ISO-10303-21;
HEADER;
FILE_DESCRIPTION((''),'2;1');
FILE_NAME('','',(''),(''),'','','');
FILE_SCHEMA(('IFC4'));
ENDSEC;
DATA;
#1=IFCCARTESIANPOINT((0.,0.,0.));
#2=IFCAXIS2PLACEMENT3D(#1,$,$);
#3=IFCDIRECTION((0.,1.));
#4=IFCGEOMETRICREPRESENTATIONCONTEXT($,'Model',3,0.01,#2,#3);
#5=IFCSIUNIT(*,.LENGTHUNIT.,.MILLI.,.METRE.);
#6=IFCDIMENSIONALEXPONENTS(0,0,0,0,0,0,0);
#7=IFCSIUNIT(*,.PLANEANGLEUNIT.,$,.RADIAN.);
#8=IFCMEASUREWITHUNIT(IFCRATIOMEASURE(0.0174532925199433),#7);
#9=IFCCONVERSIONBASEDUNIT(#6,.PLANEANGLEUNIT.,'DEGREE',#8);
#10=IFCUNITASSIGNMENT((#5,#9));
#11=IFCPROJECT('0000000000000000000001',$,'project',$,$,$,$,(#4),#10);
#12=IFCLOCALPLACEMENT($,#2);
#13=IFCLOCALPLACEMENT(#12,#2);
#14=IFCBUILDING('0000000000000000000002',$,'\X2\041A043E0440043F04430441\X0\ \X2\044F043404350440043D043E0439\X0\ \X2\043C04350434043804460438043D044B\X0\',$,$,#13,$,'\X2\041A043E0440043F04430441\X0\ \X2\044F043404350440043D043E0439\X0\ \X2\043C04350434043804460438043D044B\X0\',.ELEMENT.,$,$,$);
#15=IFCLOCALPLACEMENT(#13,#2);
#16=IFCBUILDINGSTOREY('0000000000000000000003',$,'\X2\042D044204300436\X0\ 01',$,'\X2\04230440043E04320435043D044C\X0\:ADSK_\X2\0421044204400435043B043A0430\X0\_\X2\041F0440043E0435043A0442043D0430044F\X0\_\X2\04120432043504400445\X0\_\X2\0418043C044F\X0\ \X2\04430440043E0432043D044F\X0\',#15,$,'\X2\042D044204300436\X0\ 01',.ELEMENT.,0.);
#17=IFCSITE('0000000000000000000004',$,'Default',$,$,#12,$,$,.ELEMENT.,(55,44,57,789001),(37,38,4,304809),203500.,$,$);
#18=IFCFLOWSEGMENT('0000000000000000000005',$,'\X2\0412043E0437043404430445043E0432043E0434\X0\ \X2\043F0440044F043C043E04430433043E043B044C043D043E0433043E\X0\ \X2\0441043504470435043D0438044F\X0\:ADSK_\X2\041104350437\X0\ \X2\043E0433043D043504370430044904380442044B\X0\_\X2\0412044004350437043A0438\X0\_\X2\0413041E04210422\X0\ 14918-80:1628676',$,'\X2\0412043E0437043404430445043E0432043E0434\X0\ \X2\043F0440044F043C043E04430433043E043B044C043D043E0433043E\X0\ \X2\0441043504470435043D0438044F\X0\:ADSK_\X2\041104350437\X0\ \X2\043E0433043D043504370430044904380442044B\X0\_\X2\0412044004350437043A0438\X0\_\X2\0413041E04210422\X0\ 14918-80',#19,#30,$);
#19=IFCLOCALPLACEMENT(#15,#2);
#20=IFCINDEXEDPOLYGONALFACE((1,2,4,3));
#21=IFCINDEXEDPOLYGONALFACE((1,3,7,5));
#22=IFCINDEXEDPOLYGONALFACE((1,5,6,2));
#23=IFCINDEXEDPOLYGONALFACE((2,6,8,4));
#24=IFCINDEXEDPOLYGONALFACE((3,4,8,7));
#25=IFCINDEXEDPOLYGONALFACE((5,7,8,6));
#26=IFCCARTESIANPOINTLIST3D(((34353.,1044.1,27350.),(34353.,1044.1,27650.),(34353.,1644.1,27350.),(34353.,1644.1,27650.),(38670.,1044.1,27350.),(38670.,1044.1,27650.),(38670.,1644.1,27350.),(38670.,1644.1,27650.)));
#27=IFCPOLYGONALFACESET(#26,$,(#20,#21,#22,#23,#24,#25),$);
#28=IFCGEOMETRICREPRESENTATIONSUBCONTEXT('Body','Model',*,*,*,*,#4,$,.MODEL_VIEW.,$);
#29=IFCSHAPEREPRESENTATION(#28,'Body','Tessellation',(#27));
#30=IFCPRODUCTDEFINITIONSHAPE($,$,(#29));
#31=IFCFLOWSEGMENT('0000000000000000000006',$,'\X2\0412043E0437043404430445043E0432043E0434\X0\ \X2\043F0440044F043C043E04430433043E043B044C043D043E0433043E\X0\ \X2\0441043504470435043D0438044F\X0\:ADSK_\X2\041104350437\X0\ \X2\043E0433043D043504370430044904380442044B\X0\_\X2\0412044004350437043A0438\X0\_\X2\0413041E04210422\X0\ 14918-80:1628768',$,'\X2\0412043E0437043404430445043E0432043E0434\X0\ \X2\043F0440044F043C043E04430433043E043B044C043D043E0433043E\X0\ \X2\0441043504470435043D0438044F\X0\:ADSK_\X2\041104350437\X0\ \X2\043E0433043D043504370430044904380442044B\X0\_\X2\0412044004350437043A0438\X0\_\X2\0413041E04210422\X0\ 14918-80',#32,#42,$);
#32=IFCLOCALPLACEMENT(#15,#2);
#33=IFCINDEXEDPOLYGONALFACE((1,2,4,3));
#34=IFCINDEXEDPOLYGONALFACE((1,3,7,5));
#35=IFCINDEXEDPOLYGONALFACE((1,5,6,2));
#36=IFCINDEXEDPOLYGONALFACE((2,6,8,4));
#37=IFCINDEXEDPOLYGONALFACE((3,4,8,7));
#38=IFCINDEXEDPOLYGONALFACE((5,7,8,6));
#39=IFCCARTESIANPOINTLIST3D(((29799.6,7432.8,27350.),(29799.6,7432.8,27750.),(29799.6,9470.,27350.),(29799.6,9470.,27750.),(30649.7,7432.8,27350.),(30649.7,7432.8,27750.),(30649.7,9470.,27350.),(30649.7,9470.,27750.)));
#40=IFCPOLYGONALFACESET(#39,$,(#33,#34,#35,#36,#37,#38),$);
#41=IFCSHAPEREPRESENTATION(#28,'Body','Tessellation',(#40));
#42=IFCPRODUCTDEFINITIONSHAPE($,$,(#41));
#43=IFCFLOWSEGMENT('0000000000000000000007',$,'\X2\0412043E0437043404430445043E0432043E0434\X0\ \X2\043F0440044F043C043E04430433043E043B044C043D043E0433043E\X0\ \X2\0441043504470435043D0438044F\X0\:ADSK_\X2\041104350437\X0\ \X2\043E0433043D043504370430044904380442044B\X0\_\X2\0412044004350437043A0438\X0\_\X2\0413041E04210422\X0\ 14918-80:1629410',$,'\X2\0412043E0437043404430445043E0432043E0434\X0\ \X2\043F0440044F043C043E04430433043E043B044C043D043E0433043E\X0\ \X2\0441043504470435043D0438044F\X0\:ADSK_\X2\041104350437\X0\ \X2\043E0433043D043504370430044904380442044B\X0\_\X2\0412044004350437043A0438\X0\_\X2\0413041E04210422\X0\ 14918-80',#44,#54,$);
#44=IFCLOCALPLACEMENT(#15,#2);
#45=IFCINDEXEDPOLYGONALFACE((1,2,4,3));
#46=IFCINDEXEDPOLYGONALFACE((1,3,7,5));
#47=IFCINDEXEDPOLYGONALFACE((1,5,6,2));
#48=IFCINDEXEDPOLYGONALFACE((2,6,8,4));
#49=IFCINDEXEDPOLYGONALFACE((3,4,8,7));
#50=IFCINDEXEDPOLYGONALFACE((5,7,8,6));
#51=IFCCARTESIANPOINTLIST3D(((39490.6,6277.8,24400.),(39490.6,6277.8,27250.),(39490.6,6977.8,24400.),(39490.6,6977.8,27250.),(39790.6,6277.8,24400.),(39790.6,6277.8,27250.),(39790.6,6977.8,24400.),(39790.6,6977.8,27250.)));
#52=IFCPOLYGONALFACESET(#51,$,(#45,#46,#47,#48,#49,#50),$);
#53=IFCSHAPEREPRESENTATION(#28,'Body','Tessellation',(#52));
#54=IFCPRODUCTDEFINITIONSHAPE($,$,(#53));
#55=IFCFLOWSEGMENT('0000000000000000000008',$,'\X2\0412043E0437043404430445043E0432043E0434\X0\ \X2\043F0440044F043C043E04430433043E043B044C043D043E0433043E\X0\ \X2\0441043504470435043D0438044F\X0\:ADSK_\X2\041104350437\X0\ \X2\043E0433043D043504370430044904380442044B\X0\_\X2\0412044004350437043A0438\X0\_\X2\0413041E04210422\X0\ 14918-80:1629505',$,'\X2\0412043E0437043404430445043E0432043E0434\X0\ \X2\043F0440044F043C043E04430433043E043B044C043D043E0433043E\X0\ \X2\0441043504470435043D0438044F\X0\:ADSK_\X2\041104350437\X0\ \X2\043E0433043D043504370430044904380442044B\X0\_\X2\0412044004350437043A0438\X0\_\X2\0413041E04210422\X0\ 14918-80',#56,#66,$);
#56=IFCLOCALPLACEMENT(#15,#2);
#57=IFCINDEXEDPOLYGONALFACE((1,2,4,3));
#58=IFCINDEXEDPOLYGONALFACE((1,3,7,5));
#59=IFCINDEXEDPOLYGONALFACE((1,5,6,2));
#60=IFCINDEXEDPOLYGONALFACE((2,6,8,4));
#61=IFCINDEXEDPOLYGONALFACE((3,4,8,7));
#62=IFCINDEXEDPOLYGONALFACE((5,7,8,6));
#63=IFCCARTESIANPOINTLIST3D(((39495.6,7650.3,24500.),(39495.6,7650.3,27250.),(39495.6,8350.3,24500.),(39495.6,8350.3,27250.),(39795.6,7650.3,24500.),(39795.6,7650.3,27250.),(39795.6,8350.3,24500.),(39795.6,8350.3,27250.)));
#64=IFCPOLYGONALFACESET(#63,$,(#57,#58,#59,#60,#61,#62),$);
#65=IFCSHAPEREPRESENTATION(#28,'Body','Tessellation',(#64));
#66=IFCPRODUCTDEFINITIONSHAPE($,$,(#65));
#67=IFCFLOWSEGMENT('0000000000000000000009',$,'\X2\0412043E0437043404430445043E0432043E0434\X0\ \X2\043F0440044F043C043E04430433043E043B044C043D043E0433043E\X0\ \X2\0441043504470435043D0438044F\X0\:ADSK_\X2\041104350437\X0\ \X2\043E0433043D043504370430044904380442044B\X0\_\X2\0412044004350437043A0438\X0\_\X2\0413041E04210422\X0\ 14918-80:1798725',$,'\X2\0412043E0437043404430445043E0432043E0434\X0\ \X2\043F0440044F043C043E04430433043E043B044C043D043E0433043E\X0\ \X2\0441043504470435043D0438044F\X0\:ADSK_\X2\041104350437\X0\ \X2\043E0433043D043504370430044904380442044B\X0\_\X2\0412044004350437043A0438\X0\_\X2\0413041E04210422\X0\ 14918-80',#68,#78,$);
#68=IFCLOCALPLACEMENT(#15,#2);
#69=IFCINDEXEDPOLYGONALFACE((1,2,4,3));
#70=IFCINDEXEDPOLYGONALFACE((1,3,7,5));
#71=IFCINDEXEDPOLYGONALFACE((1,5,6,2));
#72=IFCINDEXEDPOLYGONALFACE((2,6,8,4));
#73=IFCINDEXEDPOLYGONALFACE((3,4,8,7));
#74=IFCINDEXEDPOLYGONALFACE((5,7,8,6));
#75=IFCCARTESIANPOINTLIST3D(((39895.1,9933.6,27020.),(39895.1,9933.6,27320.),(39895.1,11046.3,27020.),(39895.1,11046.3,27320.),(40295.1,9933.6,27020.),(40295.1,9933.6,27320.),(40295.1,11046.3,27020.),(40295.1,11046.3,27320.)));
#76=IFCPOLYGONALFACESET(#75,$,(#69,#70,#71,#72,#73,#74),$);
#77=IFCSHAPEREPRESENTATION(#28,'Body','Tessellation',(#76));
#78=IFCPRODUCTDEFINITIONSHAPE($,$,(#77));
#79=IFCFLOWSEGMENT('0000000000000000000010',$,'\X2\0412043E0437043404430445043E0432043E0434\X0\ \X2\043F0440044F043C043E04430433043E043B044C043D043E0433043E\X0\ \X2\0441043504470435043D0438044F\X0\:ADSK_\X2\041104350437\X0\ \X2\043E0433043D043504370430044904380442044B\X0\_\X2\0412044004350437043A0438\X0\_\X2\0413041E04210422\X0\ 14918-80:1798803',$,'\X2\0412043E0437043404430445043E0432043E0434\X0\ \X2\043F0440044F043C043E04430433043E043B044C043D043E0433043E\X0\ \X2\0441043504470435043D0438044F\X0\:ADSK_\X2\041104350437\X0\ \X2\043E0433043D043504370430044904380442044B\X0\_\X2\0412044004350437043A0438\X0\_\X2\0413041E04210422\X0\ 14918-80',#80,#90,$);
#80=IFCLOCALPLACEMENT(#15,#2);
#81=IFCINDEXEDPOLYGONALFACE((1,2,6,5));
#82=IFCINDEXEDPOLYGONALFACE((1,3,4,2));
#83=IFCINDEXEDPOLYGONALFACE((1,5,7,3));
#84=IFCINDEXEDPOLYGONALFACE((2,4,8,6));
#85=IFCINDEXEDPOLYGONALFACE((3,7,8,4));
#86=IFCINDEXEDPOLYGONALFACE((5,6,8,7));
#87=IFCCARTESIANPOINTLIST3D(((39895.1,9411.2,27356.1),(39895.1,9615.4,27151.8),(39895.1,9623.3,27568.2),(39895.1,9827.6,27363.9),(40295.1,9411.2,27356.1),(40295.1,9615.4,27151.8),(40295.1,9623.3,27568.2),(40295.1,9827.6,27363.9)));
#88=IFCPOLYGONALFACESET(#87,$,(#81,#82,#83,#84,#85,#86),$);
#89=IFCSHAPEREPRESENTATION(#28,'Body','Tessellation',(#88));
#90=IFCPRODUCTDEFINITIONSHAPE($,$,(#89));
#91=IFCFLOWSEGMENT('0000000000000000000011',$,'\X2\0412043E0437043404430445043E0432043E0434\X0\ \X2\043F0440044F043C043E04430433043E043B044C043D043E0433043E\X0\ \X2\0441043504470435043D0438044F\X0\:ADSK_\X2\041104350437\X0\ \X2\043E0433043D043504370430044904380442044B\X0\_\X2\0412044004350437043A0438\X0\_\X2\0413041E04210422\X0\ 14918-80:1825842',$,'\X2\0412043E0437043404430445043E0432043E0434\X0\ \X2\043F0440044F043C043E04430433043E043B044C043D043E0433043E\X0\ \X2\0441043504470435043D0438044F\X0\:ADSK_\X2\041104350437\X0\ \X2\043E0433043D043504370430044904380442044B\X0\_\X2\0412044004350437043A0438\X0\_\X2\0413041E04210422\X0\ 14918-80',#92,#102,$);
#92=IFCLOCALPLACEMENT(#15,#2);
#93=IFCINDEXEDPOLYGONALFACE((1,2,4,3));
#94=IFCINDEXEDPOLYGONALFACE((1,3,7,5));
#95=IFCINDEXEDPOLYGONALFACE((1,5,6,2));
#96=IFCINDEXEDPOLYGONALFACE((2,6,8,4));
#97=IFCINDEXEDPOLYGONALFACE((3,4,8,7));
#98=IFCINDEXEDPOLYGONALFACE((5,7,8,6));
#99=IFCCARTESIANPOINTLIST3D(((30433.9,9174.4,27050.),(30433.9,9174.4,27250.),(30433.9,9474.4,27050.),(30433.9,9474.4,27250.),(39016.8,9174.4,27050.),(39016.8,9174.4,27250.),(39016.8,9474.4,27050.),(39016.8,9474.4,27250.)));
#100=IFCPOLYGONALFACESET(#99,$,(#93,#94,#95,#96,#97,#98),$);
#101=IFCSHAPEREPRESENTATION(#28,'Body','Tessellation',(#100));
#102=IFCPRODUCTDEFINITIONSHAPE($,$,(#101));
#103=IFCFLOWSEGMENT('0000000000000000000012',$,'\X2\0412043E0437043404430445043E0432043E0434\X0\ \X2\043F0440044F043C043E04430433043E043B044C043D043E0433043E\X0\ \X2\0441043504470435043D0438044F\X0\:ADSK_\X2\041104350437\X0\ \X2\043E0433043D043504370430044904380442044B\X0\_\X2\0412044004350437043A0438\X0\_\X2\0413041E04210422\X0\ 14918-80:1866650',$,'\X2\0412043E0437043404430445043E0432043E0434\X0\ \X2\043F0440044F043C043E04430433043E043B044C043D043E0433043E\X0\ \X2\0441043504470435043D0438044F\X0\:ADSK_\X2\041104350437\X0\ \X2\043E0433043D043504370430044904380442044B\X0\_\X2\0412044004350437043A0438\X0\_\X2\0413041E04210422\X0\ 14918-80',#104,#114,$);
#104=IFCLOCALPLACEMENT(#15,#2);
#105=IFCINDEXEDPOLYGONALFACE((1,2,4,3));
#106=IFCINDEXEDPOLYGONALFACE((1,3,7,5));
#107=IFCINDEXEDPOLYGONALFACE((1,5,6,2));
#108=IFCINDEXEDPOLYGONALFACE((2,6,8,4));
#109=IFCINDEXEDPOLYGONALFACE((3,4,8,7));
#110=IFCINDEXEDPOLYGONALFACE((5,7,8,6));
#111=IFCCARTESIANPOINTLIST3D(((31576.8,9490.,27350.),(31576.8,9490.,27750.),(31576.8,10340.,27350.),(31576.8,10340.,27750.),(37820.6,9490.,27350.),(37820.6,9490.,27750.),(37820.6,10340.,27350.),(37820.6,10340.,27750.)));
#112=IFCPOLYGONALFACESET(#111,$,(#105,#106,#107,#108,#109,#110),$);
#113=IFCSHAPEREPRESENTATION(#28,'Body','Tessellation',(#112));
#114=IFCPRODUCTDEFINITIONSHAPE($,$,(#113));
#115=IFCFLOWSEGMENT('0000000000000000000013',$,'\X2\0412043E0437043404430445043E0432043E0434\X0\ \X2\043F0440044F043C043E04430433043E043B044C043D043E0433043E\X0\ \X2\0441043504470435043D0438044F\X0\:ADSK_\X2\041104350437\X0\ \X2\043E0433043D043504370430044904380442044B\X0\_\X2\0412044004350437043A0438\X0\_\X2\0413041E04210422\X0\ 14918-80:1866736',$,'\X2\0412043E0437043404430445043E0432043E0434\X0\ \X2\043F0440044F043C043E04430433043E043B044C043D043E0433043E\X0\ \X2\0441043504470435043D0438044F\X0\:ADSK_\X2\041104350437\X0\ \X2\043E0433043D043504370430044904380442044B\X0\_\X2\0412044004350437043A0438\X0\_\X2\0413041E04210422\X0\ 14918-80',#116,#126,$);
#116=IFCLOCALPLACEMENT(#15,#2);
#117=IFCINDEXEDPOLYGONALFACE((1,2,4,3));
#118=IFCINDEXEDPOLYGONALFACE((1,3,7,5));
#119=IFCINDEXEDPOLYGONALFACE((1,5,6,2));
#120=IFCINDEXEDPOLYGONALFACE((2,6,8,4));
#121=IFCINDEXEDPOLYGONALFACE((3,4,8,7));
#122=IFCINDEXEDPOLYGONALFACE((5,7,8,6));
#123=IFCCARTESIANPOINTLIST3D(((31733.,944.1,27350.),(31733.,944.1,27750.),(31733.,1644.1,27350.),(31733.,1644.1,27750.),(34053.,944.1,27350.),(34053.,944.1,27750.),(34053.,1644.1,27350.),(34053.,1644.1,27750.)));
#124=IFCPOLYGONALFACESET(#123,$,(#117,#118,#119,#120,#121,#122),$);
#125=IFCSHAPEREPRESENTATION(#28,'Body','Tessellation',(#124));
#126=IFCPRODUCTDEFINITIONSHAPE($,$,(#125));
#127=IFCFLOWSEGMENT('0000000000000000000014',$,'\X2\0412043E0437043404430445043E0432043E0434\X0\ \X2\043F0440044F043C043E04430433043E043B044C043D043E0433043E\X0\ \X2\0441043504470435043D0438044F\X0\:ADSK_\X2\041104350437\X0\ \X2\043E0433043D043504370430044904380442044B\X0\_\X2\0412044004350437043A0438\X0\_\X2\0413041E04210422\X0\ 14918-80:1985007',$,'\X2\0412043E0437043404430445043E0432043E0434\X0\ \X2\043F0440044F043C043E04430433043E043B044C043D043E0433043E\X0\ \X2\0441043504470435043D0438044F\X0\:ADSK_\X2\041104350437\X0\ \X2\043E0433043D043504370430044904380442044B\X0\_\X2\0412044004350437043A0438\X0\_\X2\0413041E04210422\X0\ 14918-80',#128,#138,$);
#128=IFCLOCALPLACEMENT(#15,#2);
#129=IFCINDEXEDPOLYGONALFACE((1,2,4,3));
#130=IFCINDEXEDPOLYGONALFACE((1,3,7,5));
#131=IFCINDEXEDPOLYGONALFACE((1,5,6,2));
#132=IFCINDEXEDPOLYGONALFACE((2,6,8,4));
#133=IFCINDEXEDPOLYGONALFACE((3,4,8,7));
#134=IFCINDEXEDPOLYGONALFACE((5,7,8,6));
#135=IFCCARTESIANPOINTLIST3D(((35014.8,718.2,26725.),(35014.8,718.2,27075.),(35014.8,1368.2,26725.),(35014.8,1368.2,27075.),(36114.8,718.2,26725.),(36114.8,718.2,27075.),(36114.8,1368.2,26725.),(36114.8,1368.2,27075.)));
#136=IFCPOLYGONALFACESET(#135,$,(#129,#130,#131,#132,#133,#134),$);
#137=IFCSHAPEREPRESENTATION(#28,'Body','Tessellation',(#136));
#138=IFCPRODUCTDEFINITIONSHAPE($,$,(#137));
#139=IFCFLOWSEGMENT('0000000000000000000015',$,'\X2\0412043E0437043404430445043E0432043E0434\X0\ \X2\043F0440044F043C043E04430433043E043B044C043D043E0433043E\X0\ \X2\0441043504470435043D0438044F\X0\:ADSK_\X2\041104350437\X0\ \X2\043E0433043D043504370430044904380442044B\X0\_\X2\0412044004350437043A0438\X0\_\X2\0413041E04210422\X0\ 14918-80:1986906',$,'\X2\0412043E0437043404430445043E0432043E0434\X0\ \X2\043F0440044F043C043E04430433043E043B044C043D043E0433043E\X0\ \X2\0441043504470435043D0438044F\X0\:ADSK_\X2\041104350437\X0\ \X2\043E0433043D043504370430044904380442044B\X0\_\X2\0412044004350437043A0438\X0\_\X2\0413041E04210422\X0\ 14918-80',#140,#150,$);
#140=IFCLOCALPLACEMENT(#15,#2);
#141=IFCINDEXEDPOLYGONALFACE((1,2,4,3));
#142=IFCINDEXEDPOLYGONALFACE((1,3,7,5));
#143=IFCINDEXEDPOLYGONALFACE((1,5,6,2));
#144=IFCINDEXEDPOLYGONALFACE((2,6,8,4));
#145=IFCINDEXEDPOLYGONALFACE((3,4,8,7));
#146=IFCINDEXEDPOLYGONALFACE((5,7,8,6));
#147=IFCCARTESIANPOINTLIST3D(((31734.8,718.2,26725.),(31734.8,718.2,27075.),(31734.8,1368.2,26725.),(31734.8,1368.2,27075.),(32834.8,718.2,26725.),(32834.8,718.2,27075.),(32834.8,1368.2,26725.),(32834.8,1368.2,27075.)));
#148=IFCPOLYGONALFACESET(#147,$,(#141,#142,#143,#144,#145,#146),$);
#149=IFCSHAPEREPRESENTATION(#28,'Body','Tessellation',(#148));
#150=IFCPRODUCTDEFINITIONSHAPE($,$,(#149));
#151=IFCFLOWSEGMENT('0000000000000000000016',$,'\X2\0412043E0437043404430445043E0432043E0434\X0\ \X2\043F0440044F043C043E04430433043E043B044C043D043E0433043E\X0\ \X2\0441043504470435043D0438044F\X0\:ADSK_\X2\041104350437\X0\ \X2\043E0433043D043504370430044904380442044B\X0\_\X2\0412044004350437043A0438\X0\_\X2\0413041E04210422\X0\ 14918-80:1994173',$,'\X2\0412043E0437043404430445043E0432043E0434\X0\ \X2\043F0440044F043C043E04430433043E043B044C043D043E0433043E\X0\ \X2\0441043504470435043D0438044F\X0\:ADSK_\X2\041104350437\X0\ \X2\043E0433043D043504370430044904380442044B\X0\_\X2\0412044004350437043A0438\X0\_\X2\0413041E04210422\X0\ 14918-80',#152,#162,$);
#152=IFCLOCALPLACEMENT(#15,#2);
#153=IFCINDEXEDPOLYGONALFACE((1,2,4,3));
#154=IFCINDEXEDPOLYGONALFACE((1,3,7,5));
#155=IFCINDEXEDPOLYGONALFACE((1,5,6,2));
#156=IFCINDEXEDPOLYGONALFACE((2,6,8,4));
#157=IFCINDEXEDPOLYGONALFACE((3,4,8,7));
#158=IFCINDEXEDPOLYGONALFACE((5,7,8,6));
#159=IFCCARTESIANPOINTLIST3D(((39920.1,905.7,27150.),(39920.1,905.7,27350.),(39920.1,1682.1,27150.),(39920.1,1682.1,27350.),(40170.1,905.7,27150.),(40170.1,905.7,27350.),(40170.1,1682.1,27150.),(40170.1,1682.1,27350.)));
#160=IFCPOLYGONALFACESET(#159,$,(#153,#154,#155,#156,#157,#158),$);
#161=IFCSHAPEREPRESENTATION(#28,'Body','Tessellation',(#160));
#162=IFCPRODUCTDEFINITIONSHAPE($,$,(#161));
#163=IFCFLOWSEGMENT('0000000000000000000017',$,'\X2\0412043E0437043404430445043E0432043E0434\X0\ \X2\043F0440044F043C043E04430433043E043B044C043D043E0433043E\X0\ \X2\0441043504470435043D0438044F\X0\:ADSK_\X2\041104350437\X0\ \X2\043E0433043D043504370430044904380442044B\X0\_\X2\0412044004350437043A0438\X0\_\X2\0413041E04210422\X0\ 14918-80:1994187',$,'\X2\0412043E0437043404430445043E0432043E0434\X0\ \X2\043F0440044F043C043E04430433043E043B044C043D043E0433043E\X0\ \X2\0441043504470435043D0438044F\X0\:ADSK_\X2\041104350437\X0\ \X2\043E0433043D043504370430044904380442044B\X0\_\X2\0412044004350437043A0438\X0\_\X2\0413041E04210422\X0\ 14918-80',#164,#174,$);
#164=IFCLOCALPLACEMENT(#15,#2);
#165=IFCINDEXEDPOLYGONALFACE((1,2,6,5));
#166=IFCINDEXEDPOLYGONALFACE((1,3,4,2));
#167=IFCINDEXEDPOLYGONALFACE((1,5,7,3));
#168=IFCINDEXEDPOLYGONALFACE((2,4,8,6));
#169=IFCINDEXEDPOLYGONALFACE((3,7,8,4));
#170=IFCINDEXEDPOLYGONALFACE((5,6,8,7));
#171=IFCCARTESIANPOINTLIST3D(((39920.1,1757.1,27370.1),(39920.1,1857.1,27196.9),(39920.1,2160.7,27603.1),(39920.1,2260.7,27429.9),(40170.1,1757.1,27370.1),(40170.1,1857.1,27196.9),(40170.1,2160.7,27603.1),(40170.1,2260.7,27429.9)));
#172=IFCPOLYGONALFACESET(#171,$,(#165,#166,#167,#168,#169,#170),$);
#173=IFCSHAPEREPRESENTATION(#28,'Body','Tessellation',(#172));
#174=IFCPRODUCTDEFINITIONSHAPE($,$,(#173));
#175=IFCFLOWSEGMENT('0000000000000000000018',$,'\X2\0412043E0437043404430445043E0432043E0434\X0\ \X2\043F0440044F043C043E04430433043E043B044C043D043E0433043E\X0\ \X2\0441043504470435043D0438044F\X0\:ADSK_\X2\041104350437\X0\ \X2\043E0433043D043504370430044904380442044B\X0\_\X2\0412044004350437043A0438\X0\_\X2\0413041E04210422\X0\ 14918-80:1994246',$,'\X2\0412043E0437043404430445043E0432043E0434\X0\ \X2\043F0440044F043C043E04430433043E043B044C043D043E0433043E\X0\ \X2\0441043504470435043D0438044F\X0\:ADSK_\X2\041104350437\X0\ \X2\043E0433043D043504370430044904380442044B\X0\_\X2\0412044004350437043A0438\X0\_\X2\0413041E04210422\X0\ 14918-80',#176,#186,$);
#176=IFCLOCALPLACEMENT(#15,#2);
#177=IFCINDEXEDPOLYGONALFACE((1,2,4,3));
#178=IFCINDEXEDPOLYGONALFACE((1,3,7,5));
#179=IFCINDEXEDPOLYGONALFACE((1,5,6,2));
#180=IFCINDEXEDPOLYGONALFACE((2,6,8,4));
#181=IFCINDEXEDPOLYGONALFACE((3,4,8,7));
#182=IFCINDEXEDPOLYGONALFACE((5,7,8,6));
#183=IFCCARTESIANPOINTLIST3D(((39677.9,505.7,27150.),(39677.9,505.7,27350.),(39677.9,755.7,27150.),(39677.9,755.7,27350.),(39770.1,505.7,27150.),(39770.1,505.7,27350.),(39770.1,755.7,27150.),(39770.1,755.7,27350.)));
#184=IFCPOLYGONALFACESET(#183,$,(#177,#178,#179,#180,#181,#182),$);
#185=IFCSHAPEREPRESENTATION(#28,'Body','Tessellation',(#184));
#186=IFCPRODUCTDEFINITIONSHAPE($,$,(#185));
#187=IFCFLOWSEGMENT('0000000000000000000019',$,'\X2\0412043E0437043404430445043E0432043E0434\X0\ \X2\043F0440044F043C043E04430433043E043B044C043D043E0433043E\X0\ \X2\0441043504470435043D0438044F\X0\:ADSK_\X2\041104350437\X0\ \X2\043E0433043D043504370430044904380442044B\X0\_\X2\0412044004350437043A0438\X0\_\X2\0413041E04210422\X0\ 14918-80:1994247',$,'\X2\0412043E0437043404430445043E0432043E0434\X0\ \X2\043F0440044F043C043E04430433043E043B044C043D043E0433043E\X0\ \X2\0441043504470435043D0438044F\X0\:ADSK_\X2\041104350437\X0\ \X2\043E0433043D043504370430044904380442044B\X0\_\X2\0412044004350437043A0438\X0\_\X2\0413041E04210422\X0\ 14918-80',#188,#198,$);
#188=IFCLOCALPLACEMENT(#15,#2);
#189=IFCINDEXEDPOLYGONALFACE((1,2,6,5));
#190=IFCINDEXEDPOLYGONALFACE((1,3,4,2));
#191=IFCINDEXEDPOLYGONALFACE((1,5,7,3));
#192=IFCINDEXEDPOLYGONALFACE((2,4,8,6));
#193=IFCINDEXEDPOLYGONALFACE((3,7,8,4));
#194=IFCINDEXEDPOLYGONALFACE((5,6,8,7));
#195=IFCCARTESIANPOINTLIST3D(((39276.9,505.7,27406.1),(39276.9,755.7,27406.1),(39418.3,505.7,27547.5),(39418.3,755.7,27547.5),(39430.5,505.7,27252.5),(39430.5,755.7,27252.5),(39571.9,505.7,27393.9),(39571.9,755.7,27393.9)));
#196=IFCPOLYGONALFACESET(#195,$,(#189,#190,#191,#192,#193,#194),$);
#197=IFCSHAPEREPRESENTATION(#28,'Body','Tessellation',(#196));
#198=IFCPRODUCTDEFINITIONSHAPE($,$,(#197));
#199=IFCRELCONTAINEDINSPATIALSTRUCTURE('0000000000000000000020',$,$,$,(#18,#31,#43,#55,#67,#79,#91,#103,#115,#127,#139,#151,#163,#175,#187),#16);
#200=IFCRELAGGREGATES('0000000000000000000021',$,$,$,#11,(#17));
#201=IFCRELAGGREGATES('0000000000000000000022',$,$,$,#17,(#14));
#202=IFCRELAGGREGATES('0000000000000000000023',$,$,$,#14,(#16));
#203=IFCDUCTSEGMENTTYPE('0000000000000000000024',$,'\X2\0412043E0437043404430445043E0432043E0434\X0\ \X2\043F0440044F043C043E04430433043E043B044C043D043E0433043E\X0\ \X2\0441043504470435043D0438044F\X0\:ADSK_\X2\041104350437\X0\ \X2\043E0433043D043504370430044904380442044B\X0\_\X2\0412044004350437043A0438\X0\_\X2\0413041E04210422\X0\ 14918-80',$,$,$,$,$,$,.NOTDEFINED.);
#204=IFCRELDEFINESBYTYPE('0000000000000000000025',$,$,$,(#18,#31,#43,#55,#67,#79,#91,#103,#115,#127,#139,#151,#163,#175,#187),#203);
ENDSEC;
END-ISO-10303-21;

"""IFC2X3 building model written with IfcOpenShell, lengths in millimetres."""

from ifc_helpers import new_model, entity, si_unit, converted_unit, direction, frame, frame_2d, origin, origin_2d_with_axis, place, context, subcontext, project, spatial, rectangle, extrude, type_object, element, save


model = new_model("IFC2X3")

# Units and contexts
model_context = context("Model", 3, precision=0.01, world=origin(), true_north=direction((0.0, 1.0)))
body_context = subcontext(model_context, "Body", "Model", "MODEL_VIEW")
ifc_project = project(units=[si_unit("LENGTHUNIT", "METRE", prefix="MILLI"), converted_unit("PLANEANGLEUNIT", "DEGREE", entity("IfcRatioMeasure", 0.0174532925199433), si_unit("PLANEANGLEUNIT", "RADIAN"), dimensions=[0, 0, 0, 0, 0, 0, 0])], contexts=[model_context])

# Site, building, storey
site_placement = place(None, origin())
site = spatial("IfcSite", under=ifc_project, at=site_placement, Name="Default", CompositionType="ELEMENT", RefLatitude=(55, 44, 57, 789001), RefLongitude=(37, 38, 4, 304809), RefElevation=203500.0)
building_placement = place(site_placement, origin())
building = spatial("IfcBuilding", under=site, at=building_placement, Name="Корпус ядерной медицины", LongName="Корпус ядерной медицины", CompositionType="ELEMENT")
storey_placement = place(building_placement, origin())
storey = spatial("IfcBuildingStorey", under=building, at=storey_placement, Name="Этаж 01", ObjectType="Уровень:ADSK_Стрелка_Проектная_Вверх_Имя уровня", LongName="Этаж 01", CompositionType="ELEMENT", Elevation=0.0)

# Flow segments
duct_segment_type_1 = type_object("IfcDuctSegmentType", Name="Воздуховод прямоугольного сечения:ADSK_Без огнезащиты_Врезки_ГОСТ 14918-80", PredefinedType="NOTDEFINED")
flow_segment_1_placement = place(storey_placement, frame((34353.0, 1044.1, 27350.0)))
element("IfcFlowSegment", 1, at=flow_segment_1_placement, inside=storey, type_object=duct_segment_type_1, Name="Воздуховод прямоугольного сечения:ADSK_Без огнезащиты_Врезки_ГОСТ 14918-80:1628676", ObjectType="Воздуховод прямоугольного сечения:ADSK_Без огнезащиты_Врезки_ГОСТ 14918-80", context=body_context, shape_type="SweptSolid", body=[
    extrude(rectangle(XDim=4317.0, YDim=600.0, at=origin_2d_with_axis()), frame((2158.5, 300.0, 0.0), z_axis=(0.0, 0.0, 1.0), x_axis=(-1.0, 0.0, 0.0)), (0.0, 0.0, 1.0), 300.0),
])
flow_segment_2_placement = place(storey_placement, frame((29799.7, 7432.8, 27350.0)))
element("IfcFlowSegment", 2, at=flow_segment_2_placement, inside=storey, type_object=duct_segment_type_1, Name="Воздуховод прямоугольного сечения:ADSK_Без огнезащиты_Врезки_ГОСТ 14918-80:1628768", ObjectType="Воздуховод прямоугольного сечения:ADSK_Без огнезащиты_Врезки_ГОСТ 14918-80", context=body_context, shape_type="SweptSolid", body=[
    extrude(rectangle(XDim=2037.2, YDim=850.0, at=origin_2d_with_axis()), frame((425.0, 1018.6, 0.0), z_axis=(0.0, 0.0, 1.0), x_axis=(0.0, -1.0, 0.0)), (0.0, 0.0, 1.0), 400.0),
])
flow_segment_3_placement = place(storey_placement, frame((39490.6, 6277.8, 24400.0)))
element("IfcFlowSegment", 3, at=flow_segment_3_placement, inside=storey, type_object=duct_segment_type_1, Name="Воздуховод прямоугольного сечения:ADSK_Без огнезащиты_Врезки_ГОСТ 14918-80:1629410", ObjectType="Воздуховод прямоугольного сечения:ADSK_Без огнезащиты_Врезки_ГОСТ 14918-80", context=body_context, shape_type="SweptSolid", body=[
    extrude(rectangle(XDim=700.0, YDim=300.0, at=origin_2d_with_axis()), frame((150.0, 350.0, 0.0), z_axis=(0.0, 0.0, 1.0), x_axis=(0.0, 1.0, 0.0)), (0.0, 0.0, 1.0), 2850.0),
])
flow_segment_4_placement = place(storey_placement, frame((39495.6, 7650.3, 24500.0)))
element("IfcFlowSegment", 4, at=flow_segment_4_placement, inside=storey, type_object=duct_segment_type_1, Name="Воздуховод прямоугольного сечения:ADSK_Без огнезащиты_Врезки_ГОСТ 14918-80:1629505", ObjectType="Воздуховод прямоугольного сечения:ADSK_Без огнезащиты_Врезки_ГОСТ 14918-80", context=body_context, shape_type="SweptSolid", body=[
    extrude(rectangle(XDim=700.0, YDim=300.0, at=origin_2d_with_axis()), frame((150.0, 350.0, 0.0), z_axis=(0.0, 0.0, 1.0), x_axis=(0.0, 1.0, 0.0)), (0.0, 0.0, 1.0), 2750.0),
])
flow_segment_5_placement = place(storey_placement, frame((39895.1, 9933.6, 27020.0)))
element("IfcFlowSegment", 5, at=flow_segment_5_placement, inside=storey, type_object=duct_segment_type_1, Name="Воздуховод прямоугольного сечения:ADSK_Без огнезащиты_Врезки_ГОСТ 14918-80:1798725", ObjectType="Воздуховод прямоугольного сечения:ADSK_Без огнезащиты_Врезки_ГОСТ 14918-80", context=body_context, shape_type="SweptSolid", body=[
    extrude(rectangle(XDim=1112.7, YDim=400.0, at=origin_2d_with_axis()), frame((200.0, 556.4, 0.0), z_axis=(0.0, 0.0, 1.0), x_axis=(0.0, -1.0, 0.0)), (0.0, 0.0, 1.0), 300.0),
])
flow_segment_6_placement = place(storey_placement, frame((39895.1, 9411.2, 27151.8)))
element("IfcFlowSegment", 6, at=flow_segment_6_placement, inside=storey, type_object=duct_segment_type_1, Name="Воздуховод прямоугольного сечения:ADSK_Без огнезащиты_Врезки_ГОСТ 14918-80:1798803", ObjectType="Воздуховод прямоугольного сечения:ADSK_Без огнезащиты_Врезки_ГОСТ 14918-80", context=body_context, shape_type="SweptSolid", body=[
    extrude(rectangle(XDim=288.9, YDim=300.0, at=origin_2d_with_axis()), frame((0.0, 208.2, 208.2), z_axis=(1.0, 0.0, 0.0), x_axis=(0.0, -0.707107, 0.707107)), (0.0, 0.0, 1.0), 400.0),
])
flow_segment_7_placement = place(storey_placement, frame((30433.8, 9174.4, 27050.0)))
element("IfcFlowSegment", 7, at=flow_segment_7_placement, inside=storey, type_object=duct_segment_type_1, Name="Воздуховод прямоугольного сечения:ADSK_Без огнезащиты_Врезки_ГОСТ 14918-80:1825842", ObjectType="Воздуховод прямоугольного сечения:ADSK_Без огнезащиты_Врезки_ГОСТ 14918-80", context=body_context, shape_type="SweptSolid", body=[
    extrude(rectangle(XDim=8583.0, YDim=300.0, at=origin_2d_with_axis()), frame((4291.5, 150.0, 0.0)), (0.0, 0.0, 1.0), 200.0),
])
flow_segment_8_placement = place(storey_placement, frame((31576.8, 9490.0, 27350.0)))
element("IfcFlowSegment", 8, at=flow_segment_8_placement, inside=storey, type_object=duct_segment_type_1, Name="Воздуховод прямоугольного сечения:ADSK_Без огнезащиты_Врезки_ГОСТ 14918-80:1866650", ObjectType="Воздуховод прямоугольного сечения:ADSK_Без огнезащиты_Врезки_ГОСТ 14918-80", context=body_context, shape_type="SweptSolid", body=[
    extrude(rectangle(XDim=6243.8, YDim=850.0, at=origin_2d_with_axis()), frame((3121.9, 425.0, 0.0), z_axis=(0.0, 0.0, 1.0), x_axis=(-1.0, 0.0, 0.0)), (0.0, 0.0, 1.0), 400.0),
])
flow_segment_9_placement = place(storey_placement, frame((31733.0, 944.1, 27350.0)))
element("IfcFlowSegment", 9, at=flow_segment_9_placement, inside=storey, type_object=duct_segment_type_1, Name="Воздуховод прямоугольного сечения:ADSK_Без огнезащиты_Врезки_ГОСТ 14918-80:1866736", ObjectType="Воздуховод прямоугольного сечения:ADSK_Без огнезащиты_Врезки_ГОСТ 14918-80", context=body_context, shape_type="SweptSolid", body=[
    extrude(rectangle(XDim=2320.0, YDim=700.0, at=origin_2d_with_axis()), frame((1160.0, 350.0, 0.0)), (0.0, 0.0, 1.0), 400.0),
])
for number, where, name in (
    (10, (35014.8, 718.2, 26725.0), "Воздуховод прямоугольного сечения:ADSK_Без огнезащиты_Врезки_ГОСТ 14918-80:1985007"),
    (11, (31734.8, 718.2, 26725.0), "Воздуховод прямоугольного сечения:ADSK_Без огнезащиты_Врезки_ГОСТ 14918-80:1986906"),
):
    element("IfcFlowSegment", number, at=place(storey_placement, frame(where)), inside=storey, type_object=duct_segment_type_1, Name=name, ObjectType="Воздуховод прямоугольного сечения:ADSK_Без огнезащиты_Врезки_ГОСТ 14918-80", context=body_context, shape_type="SweptSolid", body=[
        extrude(rectangle(XDim=1100.0, YDim=650.0, at=origin_2d_with_axis()), frame((550.0, 325.0, 0.0)), (0.0, 0.0, 1.0), 350.0),
    ])
flow_segment_10_placement = place(storey_placement, frame((39920.1, 905.7, 27150.0)))
element("IfcFlowSegment", 12, at=flow_segment_10_placement, inside=storey, type_object=duct_segment_type_1, Name="Воздуховод прямоугольного сечения:ADSK_Без огнезащиты_Врезки_ГОСТ 14918-80:1994173", ObjectType="Воздуховод прямоугольного сечения:ADSK_Без огнезащиты_Врезки_ГОСТ 14918-80", context=body_context, shape_type="SweptSolid", body=[
    extrude(rectangle(XDim=776.4, YDim=250.0, at=origin_2d_with_axis()), frame((125.0, 388.2, 0.0), z_axis=(0.0, 0.0, 1.0), x_axis=(0.0, -1.0, 0.0)), (0.0, 0.0, 1.0), 200.0),
])
flow_segment_11_placement = place(storey_placement, frame((39920.1, 1757.1, 27196.9)))
element("IfcFlowSegment", 13, at=flow_segment_11_placement, inside=storey, type_object=duct_segment_type_1, Name="Воздуховод прямоугольного сечения:ADSK_Без огнезащиты_Врезки_ГОСТ 14918-80:1994187", ObjectType="Воздуховод прямоугольного сечения:ADSK_Без огнезащиты_Врезки_ГОСТ 14918-80", context=body_context, shape_type="SweptSolid", body=[
    extrude(rectangle(XDim=200.0, YDim=466.0, at=frame_2d((0.0, 0.0), x_axis=(0.0, 1.0))), frame((0.0, 251.8, 203.1), z_axis=(1.0, 0.0, 0.0), x_axis=(0.0, -0.866025, -0.5)), (0.0, 0.0, 1.0), 250.0),
])
flow_segment_12_placement = place(storey_placement, frame((39677.9, 505.7, 27150.0)))
element("IfcFlowSegment", 14, at=flow_segment_12_placement, inside=storey, type_object=duct_segment_type_1, Name="Воздуховод прямоугольного сечения:ADSK_Без огнезащиты_Врезки_ГОСТ 14918-80:1994246", ObjectType="Воздуховод прямоугольного сечения:ADSK_Без огнезащиты_Врезки_ГОСТ 14918-80", context=body_context, shape_type="SweptSolid", body=[
    extrude(rectangle(XDim=92.2, YDim=250.0, at=origin_2d_with_axis()), frame((46.1, 125.0, 0.0), z_axis=(0.0, 0.0, 1.0), x_axis=(-1.0, 0.0, 0.0)), (0.0, 0.0, 1.0), 200.0),
])
flow_segment_13_placement = place(storey_placement, frame((39276.9, 505.7, 27252.5)))
element("IfcFlowSegment", 15, at=flow_segment_13_placement, inside=storey, type_object=duct_segment_type_1, Name="Воздуховод прямоугольного сечения:ADSK_Без огнезащиты_Врезки_ГОСТ 14918-80:1994247", ObjectType="Воздуховод прямоугольного сечения:ADSK_Без огнезащиты_Врезки_ГОСТ 14918-80", context=body_context, shape_type="SweptSolid", body=[
    extrude(rectangle(XDim=217.2, YDim=200.0, at=origin_2d_with_axis()), frame((147.5, 0.0, 147.5), z_axis=(0.0, 1.0, 0.0), x_axis=(-0.707107, 0.0, 0.707107)), (0.0, 0.0, 1.0), 250.0),
])

save(model, "model.ifc")
